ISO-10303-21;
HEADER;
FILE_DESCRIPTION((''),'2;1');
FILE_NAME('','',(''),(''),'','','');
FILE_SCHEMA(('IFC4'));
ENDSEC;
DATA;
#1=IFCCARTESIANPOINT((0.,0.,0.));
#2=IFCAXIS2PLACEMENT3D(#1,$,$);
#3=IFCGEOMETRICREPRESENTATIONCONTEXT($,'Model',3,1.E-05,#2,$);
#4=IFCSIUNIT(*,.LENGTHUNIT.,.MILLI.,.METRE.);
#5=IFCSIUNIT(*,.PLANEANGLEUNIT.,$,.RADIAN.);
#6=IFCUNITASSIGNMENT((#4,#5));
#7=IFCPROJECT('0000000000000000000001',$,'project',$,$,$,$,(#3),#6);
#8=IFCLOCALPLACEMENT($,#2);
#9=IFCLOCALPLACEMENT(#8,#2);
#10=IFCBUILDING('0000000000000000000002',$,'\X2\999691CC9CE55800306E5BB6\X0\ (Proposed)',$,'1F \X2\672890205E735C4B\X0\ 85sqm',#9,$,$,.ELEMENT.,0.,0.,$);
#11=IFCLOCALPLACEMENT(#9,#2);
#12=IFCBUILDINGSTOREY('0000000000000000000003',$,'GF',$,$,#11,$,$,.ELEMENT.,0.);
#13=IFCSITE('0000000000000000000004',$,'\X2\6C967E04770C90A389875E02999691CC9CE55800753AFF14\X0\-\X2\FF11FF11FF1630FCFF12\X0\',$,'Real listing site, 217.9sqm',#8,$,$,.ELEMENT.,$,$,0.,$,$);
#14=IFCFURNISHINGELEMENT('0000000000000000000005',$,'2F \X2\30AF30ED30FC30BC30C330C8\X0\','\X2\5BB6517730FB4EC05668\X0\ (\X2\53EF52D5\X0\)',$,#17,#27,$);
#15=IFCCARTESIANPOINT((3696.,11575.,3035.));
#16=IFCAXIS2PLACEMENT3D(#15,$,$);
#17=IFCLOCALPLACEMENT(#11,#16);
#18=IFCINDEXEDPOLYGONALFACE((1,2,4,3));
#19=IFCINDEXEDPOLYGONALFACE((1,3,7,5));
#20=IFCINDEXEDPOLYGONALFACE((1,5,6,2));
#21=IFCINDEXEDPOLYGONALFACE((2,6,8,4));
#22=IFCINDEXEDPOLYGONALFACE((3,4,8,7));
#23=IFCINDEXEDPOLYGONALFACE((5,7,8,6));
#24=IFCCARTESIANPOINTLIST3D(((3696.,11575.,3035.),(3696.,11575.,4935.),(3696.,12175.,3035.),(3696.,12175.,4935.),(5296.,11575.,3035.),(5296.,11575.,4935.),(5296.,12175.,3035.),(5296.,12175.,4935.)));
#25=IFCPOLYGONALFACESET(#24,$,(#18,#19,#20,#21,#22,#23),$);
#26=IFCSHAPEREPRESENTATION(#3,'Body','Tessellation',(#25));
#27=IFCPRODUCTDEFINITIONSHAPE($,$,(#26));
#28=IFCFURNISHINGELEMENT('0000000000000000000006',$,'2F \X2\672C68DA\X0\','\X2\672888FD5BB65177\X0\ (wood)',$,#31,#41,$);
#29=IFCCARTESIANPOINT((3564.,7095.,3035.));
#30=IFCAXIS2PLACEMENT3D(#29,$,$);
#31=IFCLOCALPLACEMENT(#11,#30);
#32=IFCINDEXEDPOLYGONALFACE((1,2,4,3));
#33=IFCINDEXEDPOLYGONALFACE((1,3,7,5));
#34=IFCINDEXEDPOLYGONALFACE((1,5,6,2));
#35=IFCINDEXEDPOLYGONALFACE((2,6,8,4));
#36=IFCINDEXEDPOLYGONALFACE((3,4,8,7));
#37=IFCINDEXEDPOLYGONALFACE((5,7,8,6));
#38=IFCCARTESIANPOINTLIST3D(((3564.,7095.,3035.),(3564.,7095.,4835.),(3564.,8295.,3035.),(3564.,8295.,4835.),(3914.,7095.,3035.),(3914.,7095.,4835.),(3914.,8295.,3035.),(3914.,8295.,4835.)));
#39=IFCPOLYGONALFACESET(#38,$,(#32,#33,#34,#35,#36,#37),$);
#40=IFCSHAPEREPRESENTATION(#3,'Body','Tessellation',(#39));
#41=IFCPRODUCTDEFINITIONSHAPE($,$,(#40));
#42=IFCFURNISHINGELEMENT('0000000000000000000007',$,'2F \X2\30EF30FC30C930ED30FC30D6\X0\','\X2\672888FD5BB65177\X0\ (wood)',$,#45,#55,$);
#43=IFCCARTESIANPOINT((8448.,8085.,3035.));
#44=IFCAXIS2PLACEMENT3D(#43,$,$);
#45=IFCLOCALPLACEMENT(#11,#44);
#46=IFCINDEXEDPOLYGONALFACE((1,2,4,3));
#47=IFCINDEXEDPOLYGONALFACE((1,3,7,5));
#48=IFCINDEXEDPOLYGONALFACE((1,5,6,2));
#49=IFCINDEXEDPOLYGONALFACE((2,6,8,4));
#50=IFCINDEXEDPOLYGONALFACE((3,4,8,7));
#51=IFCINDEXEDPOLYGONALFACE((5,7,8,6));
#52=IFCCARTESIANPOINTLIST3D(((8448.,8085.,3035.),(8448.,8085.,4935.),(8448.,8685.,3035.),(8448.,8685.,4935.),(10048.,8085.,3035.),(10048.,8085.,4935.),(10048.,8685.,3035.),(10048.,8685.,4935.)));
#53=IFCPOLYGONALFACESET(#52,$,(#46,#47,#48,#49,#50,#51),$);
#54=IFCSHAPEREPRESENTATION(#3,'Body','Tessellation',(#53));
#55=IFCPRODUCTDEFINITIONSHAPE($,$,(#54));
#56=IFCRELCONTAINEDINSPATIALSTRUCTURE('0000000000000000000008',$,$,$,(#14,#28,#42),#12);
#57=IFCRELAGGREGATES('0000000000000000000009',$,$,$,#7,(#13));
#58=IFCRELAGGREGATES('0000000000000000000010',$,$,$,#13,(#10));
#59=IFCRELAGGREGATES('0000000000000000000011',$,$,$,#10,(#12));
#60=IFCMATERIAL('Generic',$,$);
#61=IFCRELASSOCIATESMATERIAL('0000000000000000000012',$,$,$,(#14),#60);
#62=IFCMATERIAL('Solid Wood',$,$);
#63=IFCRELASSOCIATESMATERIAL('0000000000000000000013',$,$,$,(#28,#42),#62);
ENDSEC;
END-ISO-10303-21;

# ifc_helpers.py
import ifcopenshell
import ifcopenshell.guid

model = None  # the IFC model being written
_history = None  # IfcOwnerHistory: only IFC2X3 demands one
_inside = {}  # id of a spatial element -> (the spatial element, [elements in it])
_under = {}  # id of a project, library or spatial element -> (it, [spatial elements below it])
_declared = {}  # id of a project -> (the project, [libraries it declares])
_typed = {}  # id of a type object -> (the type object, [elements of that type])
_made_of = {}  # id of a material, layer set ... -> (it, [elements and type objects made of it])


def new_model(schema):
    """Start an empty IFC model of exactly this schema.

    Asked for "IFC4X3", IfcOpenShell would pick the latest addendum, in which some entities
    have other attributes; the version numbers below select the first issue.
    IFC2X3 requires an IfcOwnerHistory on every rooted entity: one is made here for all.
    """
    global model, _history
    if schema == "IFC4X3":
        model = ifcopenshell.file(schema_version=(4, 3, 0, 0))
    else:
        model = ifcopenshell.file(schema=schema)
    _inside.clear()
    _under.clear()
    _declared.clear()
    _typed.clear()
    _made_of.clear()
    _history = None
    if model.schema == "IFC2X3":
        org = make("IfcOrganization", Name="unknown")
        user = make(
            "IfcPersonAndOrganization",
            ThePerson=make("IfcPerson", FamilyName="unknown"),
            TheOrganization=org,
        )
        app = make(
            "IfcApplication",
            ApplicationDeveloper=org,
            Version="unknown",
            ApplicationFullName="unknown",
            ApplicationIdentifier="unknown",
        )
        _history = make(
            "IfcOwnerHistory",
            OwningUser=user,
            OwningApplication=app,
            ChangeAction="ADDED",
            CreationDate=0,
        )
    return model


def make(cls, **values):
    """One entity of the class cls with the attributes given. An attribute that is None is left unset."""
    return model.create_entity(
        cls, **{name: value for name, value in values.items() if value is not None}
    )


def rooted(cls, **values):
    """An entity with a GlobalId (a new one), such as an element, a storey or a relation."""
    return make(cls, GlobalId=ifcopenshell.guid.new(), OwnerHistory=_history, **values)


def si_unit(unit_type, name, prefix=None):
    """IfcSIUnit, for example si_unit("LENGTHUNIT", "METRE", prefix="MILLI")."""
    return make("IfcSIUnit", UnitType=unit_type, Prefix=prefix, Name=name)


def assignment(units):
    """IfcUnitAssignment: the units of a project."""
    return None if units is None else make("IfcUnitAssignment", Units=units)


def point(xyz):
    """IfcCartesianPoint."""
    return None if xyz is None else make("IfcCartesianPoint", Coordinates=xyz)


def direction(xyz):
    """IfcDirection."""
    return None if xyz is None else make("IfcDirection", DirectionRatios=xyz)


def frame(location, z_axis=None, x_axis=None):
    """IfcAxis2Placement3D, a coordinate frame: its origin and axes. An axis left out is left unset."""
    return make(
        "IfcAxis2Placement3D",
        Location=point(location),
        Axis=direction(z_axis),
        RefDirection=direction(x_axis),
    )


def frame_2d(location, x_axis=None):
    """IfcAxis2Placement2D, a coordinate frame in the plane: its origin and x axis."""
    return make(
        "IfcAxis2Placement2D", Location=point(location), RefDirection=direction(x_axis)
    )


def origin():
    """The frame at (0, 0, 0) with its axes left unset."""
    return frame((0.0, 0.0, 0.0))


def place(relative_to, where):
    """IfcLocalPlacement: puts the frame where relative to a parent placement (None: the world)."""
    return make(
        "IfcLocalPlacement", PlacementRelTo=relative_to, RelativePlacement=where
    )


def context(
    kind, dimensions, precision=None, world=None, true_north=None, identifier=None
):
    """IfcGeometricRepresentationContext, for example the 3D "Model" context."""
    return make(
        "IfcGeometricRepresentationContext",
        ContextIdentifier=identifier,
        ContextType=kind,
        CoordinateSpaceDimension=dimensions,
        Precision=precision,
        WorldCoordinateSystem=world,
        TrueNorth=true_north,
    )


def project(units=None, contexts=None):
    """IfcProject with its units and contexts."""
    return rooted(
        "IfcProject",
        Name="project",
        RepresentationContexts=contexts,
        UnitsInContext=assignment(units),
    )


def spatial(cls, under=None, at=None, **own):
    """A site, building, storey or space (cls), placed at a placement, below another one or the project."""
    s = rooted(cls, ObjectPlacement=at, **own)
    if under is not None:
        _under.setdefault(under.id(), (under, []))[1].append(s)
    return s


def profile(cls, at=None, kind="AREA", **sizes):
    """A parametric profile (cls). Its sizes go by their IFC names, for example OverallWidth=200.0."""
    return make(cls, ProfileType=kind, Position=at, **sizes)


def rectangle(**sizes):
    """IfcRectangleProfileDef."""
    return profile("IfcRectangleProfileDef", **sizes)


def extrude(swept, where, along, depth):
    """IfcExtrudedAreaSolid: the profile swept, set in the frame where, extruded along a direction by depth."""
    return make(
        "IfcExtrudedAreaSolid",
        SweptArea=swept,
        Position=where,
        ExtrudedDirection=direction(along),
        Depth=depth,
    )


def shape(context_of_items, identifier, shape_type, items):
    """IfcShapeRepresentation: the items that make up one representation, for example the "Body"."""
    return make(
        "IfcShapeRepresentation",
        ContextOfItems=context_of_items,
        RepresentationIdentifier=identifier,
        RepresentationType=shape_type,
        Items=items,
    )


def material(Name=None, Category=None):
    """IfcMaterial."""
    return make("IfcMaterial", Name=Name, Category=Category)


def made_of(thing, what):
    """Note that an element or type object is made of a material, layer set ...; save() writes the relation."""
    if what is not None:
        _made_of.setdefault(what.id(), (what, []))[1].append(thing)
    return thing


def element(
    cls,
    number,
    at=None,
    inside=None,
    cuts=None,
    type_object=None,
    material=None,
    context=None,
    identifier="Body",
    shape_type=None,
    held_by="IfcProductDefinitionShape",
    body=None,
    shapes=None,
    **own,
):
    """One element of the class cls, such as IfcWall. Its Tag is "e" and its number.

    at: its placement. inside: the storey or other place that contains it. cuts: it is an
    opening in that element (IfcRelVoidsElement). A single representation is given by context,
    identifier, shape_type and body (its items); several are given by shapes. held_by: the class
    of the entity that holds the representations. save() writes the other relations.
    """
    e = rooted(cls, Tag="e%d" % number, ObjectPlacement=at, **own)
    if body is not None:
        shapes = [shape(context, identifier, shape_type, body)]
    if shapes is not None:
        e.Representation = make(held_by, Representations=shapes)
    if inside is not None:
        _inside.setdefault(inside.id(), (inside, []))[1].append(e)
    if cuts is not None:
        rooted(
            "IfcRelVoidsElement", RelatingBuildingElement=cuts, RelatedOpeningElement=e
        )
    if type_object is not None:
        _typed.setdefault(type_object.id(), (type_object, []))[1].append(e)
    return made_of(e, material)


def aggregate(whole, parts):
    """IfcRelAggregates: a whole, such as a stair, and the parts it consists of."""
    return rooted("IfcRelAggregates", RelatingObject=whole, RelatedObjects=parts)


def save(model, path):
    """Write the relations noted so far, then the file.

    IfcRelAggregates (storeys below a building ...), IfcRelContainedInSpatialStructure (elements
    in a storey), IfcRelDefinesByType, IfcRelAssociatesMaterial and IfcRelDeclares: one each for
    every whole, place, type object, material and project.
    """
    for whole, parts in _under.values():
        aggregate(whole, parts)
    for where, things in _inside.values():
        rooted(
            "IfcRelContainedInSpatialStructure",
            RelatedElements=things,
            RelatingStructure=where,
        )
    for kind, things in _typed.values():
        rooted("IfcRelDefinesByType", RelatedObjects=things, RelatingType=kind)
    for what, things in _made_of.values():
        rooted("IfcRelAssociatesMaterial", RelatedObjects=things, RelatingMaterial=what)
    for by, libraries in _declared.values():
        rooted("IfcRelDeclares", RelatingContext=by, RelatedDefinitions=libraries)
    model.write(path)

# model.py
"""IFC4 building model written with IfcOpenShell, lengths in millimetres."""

from ifc_helpers import new_model, si_unit, frame, frame_2d, origin, place, context, project, spatial, rectangle, extrude, material, element, save


model = new_model("IFC4")

# Units and contexts
model_context = context("Model", 3, precision=1e-05, world=origin())
ifc_project = project(units=[si_unit("LENGTHUNIT", "METRE", prefix="MILLI"), si_unit("PLANEANGLEUNIT", "RADIAN")], contexts=[model_context])

# Site, building, storey
site_placement = place(None, origin())
site = spatial("IfcSite", under=ifc_project, at=site_placement, Name="沖縄県那覇市首里鳥堀町４-１１６ー２", ObjectType="Real listing site, 217.9sqm", CompositionType="ELEMENT", RefElevation=0.0)
building_placement = place(site_placement, origin())
building = spatial("IfcBuilding", under=site, at=building_placement, Name="首里鳥堀の家 (Proposed)", ObjectType="1F 木造平屋 85sqm", CompositionType="ELEMENT", ElevationOfRefHeight=0.0, ElevationOfTerrain=0.0)
storey_placement = place(building_placement, origin())
storey = spatial("IfcBuildingStorey", under=building, at=storey_placement, Name="GF", CompositionType="ELEMENT", Elevation=0.0)

# Shared definitions
ifc_material_1 = material(Name="Solid Wood")

# Shared definitions
ifc_material_2 = material(Name="Generic")

# Furnishing elements
furnishing_1_placement = place(storey_placement, frame((3696.0, 11575.0, 3035.0)))
element("IfcFurnishingElement", 1, at=furnishing_1_placement, inside=storey, material=ifc_material_2, Name="2F クローゼット", Description="家具・什器 (可動)", context=model_context, shape_type="SweptSolid", body=[
    extrude(rectangle(XDim=1600.0, YDim=600.0, at=frame_2d((800.0, 300.0))), frame((3696.0, 11575.0, 3035.0)), (0.0, 0.0, 1.0), 1900.0),
])
furnishing_2_placement = place(storey_placement, frame((3564.0, 7095.0, 3035.0)))
element("IfcFurnishingElement", 2, at=furnishing_2_placement, inside=storey, material=ifc_material_1, Name="2F 本棚", Description="木製家具 (wood)", context=model_context, shape_type="SweptSolid", body=[
    extrude(rectangle(XDim=350.0, YDim=1200.0, at=frame_2d((175.0, 600.0))), frame((3564.0, 7095.0, 3035.0)), (0.0, 0.0, 1.0), 1800.0),
])
furnishing_3_placement = place(storey_placement, frame((8448.0, 8085.0, 3035.0)))
element("IfcFurnishingElement", 3, at=furnishing_3_placement, inside=storey, material=ifc_material_1, Name="2F ワードローブ", Description="木製家具 (wood)", context=model_context, shape_type="SweptSolid", body=[
    extrude(rectangle(XDim=1600.0, YDim=600.0, at=frame_2d((800.0, 300.0))), frame((8448.0, 8085.0, 3035.0)), (0.0, 0.0, 1.0), 1900.0),
])

save(model, "model.ifc")
